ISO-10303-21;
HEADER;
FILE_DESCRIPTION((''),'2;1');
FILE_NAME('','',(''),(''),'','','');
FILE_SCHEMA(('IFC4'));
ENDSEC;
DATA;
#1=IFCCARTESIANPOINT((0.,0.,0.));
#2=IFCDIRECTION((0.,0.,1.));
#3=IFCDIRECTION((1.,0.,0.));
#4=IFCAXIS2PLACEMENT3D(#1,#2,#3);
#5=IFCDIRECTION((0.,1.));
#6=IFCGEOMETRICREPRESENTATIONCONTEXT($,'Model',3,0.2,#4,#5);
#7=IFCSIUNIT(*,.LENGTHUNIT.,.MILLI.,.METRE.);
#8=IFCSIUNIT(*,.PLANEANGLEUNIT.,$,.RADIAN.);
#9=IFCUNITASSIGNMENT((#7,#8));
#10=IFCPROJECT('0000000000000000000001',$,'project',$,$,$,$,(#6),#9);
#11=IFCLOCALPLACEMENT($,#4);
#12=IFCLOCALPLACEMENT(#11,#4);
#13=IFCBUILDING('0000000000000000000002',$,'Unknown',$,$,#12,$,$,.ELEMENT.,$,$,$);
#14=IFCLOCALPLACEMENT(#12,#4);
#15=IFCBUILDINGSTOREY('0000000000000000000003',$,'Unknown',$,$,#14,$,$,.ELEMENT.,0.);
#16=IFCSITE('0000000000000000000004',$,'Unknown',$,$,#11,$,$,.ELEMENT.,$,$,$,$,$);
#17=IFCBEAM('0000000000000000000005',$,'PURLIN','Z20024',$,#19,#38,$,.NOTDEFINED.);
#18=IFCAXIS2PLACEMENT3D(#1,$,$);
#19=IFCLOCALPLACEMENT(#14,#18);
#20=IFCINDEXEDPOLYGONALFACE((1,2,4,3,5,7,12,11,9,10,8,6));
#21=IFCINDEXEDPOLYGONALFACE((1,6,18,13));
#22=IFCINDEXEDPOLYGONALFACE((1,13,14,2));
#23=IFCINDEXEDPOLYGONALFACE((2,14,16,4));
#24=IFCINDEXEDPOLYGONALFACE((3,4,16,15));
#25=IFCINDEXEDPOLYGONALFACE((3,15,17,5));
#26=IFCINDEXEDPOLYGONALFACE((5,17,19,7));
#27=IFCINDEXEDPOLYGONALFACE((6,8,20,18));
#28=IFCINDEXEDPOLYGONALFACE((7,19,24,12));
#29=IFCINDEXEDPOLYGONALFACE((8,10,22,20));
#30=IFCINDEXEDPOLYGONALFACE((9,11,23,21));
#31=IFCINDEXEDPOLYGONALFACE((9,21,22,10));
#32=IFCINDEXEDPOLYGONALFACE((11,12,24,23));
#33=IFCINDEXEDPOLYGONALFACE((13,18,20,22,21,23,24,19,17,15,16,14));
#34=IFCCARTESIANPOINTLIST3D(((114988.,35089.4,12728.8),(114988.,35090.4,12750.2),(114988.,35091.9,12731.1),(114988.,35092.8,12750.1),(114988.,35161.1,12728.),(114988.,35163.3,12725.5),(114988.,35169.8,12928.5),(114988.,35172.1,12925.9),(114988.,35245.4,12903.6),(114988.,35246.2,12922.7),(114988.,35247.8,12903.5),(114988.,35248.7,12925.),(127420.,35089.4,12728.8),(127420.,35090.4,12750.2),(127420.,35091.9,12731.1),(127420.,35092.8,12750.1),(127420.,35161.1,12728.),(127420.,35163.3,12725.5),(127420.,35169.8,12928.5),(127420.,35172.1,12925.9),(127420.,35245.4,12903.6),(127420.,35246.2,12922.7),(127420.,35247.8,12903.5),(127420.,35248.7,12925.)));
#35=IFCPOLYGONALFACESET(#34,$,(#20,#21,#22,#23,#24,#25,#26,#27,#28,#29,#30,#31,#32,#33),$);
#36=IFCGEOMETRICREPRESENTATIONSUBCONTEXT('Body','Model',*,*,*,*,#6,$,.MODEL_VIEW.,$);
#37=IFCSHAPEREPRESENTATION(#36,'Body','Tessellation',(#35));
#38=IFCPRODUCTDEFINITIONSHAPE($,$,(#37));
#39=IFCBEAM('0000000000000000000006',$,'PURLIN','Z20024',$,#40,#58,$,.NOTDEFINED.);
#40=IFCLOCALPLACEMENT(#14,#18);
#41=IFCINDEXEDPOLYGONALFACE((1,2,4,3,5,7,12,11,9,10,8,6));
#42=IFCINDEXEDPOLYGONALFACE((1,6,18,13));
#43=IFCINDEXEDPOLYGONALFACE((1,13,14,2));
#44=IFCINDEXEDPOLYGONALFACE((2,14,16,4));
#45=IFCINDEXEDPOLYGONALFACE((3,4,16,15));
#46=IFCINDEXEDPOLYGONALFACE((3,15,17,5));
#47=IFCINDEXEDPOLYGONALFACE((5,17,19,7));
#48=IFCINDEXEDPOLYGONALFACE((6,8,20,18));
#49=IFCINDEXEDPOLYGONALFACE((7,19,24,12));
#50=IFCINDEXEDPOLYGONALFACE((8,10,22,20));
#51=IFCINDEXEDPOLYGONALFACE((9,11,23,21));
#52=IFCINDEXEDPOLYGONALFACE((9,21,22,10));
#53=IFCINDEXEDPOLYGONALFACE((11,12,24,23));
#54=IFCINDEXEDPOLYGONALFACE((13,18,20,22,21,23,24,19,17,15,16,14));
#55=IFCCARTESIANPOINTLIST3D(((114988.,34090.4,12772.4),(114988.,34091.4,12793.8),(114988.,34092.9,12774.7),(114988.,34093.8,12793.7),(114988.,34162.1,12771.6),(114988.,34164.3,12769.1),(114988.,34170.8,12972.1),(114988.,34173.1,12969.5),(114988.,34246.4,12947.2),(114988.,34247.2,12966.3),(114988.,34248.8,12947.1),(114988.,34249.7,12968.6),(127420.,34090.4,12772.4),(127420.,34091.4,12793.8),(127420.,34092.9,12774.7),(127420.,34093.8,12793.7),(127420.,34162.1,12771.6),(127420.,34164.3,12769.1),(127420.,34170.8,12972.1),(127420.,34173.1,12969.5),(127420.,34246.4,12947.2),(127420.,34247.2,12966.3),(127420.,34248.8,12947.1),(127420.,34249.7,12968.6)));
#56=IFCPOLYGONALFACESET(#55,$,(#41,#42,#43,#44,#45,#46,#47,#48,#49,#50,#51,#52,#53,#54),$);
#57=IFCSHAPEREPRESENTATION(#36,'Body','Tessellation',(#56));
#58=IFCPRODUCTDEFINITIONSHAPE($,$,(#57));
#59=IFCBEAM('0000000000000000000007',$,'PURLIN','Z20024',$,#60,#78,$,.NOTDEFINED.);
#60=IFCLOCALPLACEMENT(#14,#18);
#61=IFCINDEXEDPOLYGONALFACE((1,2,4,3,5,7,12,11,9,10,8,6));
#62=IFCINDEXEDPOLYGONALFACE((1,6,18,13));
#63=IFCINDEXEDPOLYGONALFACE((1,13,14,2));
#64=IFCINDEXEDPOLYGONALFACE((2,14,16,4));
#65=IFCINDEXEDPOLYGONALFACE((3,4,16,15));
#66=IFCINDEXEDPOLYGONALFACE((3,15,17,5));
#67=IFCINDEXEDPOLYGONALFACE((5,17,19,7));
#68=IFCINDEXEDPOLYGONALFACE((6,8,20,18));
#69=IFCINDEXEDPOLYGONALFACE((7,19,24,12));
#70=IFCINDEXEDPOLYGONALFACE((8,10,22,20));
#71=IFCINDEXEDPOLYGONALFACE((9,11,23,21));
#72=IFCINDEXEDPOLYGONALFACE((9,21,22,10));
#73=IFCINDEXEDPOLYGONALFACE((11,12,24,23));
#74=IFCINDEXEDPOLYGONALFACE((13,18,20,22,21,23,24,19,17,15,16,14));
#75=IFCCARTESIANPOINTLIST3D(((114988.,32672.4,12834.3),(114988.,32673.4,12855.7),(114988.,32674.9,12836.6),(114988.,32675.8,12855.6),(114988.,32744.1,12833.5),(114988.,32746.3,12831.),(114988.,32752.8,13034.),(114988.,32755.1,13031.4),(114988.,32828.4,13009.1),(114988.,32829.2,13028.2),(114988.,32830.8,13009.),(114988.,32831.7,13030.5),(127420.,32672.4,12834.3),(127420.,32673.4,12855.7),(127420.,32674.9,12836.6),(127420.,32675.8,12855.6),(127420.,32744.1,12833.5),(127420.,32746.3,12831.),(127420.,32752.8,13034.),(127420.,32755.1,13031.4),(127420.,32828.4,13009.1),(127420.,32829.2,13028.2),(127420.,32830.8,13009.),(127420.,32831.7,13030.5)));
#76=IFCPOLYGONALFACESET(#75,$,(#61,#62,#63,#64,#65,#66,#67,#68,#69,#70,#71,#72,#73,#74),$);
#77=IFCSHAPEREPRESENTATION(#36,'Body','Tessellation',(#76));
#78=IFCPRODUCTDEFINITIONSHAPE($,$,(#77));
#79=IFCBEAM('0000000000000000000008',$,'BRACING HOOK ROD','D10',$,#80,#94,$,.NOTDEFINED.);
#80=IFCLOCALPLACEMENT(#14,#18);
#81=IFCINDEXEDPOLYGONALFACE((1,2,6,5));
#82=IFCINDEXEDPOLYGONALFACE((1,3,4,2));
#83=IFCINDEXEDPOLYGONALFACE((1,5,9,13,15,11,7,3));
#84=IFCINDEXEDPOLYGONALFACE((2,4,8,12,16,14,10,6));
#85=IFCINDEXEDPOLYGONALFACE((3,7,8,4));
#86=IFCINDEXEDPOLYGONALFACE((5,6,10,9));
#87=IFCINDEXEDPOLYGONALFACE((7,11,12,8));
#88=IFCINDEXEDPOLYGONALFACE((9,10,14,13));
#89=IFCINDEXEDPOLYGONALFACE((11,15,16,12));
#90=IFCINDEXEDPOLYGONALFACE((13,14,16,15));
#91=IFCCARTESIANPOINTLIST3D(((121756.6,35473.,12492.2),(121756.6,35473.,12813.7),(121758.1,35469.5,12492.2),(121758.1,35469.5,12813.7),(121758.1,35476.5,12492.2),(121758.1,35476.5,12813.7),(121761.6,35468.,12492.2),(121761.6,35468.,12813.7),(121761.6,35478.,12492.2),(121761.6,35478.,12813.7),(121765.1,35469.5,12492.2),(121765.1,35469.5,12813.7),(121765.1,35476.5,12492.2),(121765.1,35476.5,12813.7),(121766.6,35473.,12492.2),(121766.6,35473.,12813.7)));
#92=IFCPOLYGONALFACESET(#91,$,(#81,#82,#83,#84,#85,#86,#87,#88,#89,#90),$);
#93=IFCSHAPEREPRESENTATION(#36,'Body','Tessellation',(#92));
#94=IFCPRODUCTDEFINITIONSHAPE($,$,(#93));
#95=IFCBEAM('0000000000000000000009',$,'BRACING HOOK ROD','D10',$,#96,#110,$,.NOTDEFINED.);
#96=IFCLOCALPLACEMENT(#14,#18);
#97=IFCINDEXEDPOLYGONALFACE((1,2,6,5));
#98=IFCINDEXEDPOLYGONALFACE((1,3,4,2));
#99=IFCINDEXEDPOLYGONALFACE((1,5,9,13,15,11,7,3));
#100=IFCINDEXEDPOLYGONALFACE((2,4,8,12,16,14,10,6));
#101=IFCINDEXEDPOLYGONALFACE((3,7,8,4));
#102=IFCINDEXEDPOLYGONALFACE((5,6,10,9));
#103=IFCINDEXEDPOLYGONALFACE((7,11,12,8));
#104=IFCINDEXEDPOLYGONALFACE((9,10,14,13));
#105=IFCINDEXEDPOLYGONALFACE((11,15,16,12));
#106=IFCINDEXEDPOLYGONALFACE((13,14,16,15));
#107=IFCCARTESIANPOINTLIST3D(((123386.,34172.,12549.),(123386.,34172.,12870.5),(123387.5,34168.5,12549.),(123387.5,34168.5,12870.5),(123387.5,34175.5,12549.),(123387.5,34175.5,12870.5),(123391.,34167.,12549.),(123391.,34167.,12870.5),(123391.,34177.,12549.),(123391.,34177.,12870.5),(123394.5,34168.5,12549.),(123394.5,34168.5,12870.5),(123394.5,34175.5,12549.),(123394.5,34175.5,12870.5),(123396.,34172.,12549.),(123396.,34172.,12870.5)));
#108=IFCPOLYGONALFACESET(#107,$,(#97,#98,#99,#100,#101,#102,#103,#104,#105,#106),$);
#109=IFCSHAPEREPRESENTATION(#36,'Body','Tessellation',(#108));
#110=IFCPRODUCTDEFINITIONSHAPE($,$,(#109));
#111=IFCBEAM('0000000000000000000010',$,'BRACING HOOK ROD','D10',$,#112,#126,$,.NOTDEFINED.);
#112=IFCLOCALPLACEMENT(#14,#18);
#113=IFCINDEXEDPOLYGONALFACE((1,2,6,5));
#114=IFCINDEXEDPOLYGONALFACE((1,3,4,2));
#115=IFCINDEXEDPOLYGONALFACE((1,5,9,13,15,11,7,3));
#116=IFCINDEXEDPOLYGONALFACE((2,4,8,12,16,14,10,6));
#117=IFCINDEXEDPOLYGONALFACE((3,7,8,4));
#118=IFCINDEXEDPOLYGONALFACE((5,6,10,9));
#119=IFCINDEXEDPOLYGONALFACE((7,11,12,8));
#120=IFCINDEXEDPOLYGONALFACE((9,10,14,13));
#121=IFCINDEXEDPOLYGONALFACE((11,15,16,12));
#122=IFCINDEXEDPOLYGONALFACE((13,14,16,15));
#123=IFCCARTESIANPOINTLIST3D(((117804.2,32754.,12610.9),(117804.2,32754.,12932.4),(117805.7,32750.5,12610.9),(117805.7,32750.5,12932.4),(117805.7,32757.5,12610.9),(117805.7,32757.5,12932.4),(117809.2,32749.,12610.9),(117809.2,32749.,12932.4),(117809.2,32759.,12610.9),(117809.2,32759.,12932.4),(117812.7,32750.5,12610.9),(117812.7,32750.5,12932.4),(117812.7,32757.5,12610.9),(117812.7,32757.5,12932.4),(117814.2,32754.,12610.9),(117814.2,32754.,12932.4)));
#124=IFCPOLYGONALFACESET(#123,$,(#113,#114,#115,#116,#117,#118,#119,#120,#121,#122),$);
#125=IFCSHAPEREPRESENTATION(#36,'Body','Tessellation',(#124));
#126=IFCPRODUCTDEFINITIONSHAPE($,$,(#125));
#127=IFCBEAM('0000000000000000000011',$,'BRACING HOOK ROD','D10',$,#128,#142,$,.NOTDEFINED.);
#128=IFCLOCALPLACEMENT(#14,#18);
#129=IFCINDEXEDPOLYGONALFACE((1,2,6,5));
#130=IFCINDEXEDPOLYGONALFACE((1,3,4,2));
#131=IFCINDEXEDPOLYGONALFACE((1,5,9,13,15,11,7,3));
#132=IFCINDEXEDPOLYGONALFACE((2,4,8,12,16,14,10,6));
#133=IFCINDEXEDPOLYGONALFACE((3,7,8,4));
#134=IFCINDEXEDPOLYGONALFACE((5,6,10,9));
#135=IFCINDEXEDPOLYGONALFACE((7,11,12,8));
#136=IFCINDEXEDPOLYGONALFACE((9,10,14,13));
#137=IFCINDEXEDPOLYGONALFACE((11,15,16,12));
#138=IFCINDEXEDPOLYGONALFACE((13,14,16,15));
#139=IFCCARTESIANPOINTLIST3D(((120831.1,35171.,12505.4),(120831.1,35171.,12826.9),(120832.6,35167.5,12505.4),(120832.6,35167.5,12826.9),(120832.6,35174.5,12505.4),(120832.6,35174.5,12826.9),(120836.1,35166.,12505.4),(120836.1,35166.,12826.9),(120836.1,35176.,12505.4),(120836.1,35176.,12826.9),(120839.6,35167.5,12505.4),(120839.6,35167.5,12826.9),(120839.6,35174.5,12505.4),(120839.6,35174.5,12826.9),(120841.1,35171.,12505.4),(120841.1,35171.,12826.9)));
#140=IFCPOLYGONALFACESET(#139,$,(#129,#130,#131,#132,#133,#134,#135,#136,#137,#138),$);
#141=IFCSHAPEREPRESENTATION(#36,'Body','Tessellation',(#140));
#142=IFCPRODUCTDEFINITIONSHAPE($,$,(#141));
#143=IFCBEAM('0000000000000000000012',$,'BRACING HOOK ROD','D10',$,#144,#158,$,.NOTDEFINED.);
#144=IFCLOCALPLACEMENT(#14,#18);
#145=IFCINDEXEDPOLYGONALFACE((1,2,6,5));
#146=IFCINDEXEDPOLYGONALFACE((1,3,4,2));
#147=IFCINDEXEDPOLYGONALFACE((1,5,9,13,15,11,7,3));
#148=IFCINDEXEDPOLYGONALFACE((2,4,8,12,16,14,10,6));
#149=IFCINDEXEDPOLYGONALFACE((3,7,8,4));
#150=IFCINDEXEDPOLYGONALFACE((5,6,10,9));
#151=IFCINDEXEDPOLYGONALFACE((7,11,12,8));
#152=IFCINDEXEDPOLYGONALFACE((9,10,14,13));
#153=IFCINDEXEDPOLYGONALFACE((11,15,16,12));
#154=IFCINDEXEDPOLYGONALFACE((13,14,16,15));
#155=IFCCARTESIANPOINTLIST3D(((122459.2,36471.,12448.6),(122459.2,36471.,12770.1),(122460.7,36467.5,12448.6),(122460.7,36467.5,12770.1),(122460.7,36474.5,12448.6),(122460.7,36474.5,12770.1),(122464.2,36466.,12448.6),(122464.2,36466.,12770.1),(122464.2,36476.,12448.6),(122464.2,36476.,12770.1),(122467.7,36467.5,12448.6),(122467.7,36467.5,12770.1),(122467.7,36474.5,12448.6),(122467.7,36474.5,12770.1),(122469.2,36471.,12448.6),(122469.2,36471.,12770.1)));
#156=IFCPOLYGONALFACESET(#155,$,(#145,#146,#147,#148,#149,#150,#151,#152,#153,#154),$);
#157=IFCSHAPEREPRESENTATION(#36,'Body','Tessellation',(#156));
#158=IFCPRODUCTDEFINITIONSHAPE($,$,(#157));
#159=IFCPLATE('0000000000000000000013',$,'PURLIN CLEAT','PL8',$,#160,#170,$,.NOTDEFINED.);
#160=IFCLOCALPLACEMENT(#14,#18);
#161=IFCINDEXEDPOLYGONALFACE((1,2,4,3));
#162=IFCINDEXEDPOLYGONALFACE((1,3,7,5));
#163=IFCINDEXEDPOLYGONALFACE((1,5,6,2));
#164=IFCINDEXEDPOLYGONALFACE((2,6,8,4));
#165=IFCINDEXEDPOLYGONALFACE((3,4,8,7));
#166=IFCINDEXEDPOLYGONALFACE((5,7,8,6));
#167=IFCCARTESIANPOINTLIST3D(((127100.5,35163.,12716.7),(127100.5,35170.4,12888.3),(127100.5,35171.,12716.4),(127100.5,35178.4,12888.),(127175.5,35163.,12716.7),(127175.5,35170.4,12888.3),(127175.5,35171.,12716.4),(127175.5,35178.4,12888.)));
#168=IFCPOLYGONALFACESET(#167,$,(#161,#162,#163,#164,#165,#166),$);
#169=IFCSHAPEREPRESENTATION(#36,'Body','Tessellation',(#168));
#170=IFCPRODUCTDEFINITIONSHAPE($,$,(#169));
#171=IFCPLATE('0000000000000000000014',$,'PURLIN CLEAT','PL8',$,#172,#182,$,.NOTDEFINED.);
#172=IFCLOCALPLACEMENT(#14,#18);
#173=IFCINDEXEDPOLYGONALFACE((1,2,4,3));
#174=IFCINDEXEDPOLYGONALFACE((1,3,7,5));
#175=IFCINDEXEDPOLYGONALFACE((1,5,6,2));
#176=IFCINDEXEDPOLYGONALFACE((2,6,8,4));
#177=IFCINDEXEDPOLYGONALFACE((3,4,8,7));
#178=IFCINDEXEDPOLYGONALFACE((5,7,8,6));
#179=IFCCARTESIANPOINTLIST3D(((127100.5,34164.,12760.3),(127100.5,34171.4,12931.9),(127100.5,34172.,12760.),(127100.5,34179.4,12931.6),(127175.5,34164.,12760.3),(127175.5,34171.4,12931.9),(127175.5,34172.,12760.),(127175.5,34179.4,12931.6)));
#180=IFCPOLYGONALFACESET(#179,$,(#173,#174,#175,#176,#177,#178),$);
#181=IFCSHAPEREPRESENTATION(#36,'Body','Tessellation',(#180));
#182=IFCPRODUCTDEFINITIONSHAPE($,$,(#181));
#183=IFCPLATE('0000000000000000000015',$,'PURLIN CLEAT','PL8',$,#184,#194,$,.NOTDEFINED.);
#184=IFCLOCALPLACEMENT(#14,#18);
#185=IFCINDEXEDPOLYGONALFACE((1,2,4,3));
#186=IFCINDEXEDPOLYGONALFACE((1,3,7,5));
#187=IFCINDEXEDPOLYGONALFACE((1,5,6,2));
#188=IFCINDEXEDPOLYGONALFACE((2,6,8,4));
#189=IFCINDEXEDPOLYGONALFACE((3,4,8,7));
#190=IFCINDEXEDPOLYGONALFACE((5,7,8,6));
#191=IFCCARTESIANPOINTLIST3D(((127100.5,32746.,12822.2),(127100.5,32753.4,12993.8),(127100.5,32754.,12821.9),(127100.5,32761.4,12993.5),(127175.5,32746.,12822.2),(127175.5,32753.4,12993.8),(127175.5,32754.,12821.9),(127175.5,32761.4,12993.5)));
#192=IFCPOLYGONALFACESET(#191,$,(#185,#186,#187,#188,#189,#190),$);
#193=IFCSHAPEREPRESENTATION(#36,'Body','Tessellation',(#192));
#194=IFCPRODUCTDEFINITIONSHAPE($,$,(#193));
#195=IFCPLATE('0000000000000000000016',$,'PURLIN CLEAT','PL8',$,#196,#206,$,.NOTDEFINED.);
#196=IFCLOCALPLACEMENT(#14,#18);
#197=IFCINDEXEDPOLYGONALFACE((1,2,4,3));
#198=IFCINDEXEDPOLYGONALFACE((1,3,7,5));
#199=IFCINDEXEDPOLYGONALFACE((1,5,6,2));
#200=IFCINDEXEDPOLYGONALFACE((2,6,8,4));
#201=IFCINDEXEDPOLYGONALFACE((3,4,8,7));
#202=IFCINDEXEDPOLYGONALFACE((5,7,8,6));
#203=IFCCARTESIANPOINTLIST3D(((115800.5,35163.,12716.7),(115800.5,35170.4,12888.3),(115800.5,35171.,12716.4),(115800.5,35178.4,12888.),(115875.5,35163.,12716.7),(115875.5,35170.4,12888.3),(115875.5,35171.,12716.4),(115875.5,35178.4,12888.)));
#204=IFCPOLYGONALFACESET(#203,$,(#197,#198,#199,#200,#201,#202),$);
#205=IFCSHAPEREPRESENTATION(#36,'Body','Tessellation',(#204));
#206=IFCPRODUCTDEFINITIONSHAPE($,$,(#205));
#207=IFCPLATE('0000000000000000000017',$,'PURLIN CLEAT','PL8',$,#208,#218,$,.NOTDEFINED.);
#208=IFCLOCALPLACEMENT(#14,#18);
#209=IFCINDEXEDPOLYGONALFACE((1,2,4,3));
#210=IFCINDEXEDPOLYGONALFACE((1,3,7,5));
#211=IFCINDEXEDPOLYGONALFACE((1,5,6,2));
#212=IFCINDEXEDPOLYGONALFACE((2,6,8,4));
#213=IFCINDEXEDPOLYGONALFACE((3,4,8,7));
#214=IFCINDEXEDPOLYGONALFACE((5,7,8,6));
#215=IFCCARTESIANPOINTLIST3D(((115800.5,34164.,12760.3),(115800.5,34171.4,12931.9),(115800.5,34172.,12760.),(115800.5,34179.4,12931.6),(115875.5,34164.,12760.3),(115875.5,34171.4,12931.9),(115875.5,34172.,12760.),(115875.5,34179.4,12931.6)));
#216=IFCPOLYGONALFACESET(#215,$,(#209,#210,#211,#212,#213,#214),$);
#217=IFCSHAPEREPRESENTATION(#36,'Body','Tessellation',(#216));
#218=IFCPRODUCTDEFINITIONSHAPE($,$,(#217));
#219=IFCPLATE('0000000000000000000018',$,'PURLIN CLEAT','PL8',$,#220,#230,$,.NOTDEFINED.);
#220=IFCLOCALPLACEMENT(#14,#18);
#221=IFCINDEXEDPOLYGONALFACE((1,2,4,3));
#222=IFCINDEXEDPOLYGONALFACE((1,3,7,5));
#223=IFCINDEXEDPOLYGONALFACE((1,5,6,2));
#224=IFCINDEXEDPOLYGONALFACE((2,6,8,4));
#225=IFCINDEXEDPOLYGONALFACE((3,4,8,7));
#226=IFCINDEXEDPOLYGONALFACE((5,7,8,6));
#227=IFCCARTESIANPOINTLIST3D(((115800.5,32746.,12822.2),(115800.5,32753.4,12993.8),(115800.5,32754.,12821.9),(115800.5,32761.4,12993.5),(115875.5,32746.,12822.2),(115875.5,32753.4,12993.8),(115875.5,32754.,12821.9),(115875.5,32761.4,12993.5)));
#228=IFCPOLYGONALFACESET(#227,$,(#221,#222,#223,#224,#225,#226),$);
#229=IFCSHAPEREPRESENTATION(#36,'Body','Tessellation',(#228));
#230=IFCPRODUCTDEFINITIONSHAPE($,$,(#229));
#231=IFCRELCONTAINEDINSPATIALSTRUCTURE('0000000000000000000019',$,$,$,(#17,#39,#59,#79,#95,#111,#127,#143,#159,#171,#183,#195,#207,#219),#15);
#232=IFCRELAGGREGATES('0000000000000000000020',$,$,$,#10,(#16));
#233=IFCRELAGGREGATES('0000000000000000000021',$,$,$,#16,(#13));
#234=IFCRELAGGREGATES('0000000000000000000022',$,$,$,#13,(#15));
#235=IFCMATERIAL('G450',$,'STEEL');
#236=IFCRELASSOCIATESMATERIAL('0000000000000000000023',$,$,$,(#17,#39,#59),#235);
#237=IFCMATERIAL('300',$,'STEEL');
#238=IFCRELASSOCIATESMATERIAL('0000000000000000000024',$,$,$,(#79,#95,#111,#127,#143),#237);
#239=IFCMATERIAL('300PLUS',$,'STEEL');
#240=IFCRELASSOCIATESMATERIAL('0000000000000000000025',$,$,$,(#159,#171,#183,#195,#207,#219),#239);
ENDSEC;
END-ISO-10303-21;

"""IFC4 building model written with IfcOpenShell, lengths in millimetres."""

from ifc_helpers import new_model, si_unit, direction, frame, origin_with_axes, place, context, subcontext, project, spatial, line, indexed_curve, outline, extrude, material, element, save


model = new_model("IFC4")

# Units and contexts
model_context = context("Model", 3, precision=0.2, world=origin_with_axes(), true_north=direction((0.0, 1.0)))
body_context = subcontext(model_context, "Body", "Model", "MODEL_VIEW")
ifc_project = project(units=[si_unit("LENGTHUNIT", "METRE", prefix="MILLI"), si_unit("PLANEANGLEUNIT", "RADIAN")], contexts=[model_context])

# Site, building, storey
site_placement = place(None, origin_with_axes())
site = spatial("IfcSite", under=ifc_project, at=site_placement, Name="Unknown", CompositionType="ELEMENT")
building_placement = place(site_placement, origin_with_axes())
building = spatial("IfcBuilding", under=site, at=building_placement, Name="Unknown", CompositionType="ELEMENT")
storey_placement = place(building_placement, origin_with_axes())
storey = spatial("IfcBuildingStorey", under=building, at=storey_placement, Name="Unknown", CompositionType="ELEMENT", Elevation=0.0)

# Beams
ifc_material_1 = material(Name="G450", Category="STEEL")
for number, where, z_axis, x_axis, name in (
    (1, (114988.0, 35166.6, 12827.0), (0.0, -0.999048, 0.043619), (1.0, 0.0, 0.0), "PURLIN"),
    (2, (114988.0, 34167.6, 12870.6), (0.0, -0.999048, 0.043619), (1.0, 0.0, 0.0), "PURLIN"),
    (3, (114988.0, 32749.6, 12932.5), (0.0, -0.999048, 0.043619), (1.0, 0.0, 0.0), "PURLIN"),
):
    element("IfcBeam", number, at=place(storey_placement, frame(where, z_axis=z_axis, x_axis=x_axis)), inside=storey, material=ifc_material_1, Name=name, Description="Z20024", PredefinedType="NOTDEFINED", context=body_context, shape_type="SolidModel", body=[
        extrude(outline(indexed_curve([(72.8, -101.5), (72.8, -80.0), (70.4, -80.0), (70.4, -99.1), (1.2, -99.1), (1.2, 101.5), (-77.8, 101.5), (-77.8, 80.0), (-75.4, 80.0), (-75.4, 99.1), (-1.2, 99.1), (-1.2, -101.5)], segments=[line(1, 2, 3, 4, 5, 6, 7, 8, 9, 10, 11, 12, 1)])), frame((0.0, 0.0, 0.0), z_axis=(-1.0, 0.0, 0.0), x_axis=(0.0, 0.0, 1.0)), (0.0, 0.0, -1.0), 12432.0),
    ])
ifc_material_2 = material(Name="300", Category="STEEL")
for number, where, z_axis, x_axis, name in (
    (4, (121761.6, 35473.0, 12813.7), (1.0, 0.0, 0.0), (0.0, 0.0, -1.0), "BRACING HOOK ROD"),
    (5, (123391.0, 34172.0, 12870.5), (1.0, 0.0, 0.0), (0.0, 0.0, -1.0), "BRACING HOOK ROD"),
    (6, (117809.2, 32754.0, 12932.4), (1.0, 0.0, 0.0), (0.0, 0.0, -1.0), "BRACING HOOK ROD"),
    (7, (120836.1, 35171.0, 12826.9), (1.0, 0.0, 0.0), (0.0, 0.0, -1.0), "BRACING HOOK ROD"),
    (8, (122464.2, 36471.0, 12770.1), (1.0, 0.0, 0.0), (0.0, 0.0, -1.0), "BRACING HOOK ROD"),
):
    element("IfcBeam", number, at=place(storey_placement, frame(where, z_axis=z_axis, x_axis=x_axis)), inside=storey, material=ifc_material_2, Name=name, Description="D10", PredefinedType="NOTDEFINED", context=body_context, shape_type="SolidModel", body=[
        extrude(outline(indexed_curve([(5.0, 0.0), (3.5, 3.5), (0.0, 5.0), (-3.5, 3.5), (-5.0, 0.0), (-3.5, -3.5), (0.0, -5.0), (3.5, -3.5)], segments=[line(1, 2, 3, 4, 5, 6, 7, 8, 1)])), frame((0.0, 0.0, 0.0), z_axis=(-1.0, 0.0, 0.0), x_axis=(0.0, 0.0, 1.0)), (0.0, 0.0, -1.0), 321.5),
    ])

# Plates
ifc_material_3 = material(Name="300PLUS", Category="STEEL")
for number, where, z_axis, x_axis, name in (
    (9, (127100.5, 35167.0, 12716.6), (0.0, -0.999071, 0.043084), (1.0, 0.0, 0.0), "PURLIN CLEAT"),
    (10, (127100.5, 34168.0, 12760.2), (0.0, -0.999071, 0.043084), (1.0, 0.0, 0.0), "PURLIN CLEAT"),
    (11, (127100.5, 32750.0, 12822.1), (0.0, -0.999071, 0.043084), (1.0, 0.0, 0.0), "PURLIN CLEAT"),
    (12, (115800.5, 35167.0, 12716.6), (0.0, -0.999071, 0.043084), (1.0, 0.0, 0.0), "PURLIN CLEAT"),
    (13, (115800.5, 34168.0, 12760.2), (0.0, -0.999071, 0.043084), (1.0, 0.0, 0.0), "PURLIN CLEAT"),
    (14, (115800.5, 32750.0, 12822.1), (0.0, -0.999071, 0.043084), (1.0, 0.0, 0.0), "PURLIN CLEAT"),
):
    element("IfcPlate", number, at=place(storey_placement, frame(where, z_axis=z_axis, x_axis=x_axis)), inside=storey, material=ifc_material_3, Name=name, Description="PL8", PredefinedType="NOTDEFINED", context=body_context, shape_type="SolidModel", body=[
        extrude(outline(indexed_curve([(0.0, 0.0), (75.0, 0.0), (75.0, 171.8), (0.0, 171.8)], segments=[line(1, 2, 3, 4, 1)])), frame((0.0, 0.0, 4.0), z_axis=(0.0, 0.0, 1.0), x_axis=(1.0, 0.0, 0.0)), (0.0, 0.0, -1.0), 8.0),
    ])

save(model, "model.ifc")
